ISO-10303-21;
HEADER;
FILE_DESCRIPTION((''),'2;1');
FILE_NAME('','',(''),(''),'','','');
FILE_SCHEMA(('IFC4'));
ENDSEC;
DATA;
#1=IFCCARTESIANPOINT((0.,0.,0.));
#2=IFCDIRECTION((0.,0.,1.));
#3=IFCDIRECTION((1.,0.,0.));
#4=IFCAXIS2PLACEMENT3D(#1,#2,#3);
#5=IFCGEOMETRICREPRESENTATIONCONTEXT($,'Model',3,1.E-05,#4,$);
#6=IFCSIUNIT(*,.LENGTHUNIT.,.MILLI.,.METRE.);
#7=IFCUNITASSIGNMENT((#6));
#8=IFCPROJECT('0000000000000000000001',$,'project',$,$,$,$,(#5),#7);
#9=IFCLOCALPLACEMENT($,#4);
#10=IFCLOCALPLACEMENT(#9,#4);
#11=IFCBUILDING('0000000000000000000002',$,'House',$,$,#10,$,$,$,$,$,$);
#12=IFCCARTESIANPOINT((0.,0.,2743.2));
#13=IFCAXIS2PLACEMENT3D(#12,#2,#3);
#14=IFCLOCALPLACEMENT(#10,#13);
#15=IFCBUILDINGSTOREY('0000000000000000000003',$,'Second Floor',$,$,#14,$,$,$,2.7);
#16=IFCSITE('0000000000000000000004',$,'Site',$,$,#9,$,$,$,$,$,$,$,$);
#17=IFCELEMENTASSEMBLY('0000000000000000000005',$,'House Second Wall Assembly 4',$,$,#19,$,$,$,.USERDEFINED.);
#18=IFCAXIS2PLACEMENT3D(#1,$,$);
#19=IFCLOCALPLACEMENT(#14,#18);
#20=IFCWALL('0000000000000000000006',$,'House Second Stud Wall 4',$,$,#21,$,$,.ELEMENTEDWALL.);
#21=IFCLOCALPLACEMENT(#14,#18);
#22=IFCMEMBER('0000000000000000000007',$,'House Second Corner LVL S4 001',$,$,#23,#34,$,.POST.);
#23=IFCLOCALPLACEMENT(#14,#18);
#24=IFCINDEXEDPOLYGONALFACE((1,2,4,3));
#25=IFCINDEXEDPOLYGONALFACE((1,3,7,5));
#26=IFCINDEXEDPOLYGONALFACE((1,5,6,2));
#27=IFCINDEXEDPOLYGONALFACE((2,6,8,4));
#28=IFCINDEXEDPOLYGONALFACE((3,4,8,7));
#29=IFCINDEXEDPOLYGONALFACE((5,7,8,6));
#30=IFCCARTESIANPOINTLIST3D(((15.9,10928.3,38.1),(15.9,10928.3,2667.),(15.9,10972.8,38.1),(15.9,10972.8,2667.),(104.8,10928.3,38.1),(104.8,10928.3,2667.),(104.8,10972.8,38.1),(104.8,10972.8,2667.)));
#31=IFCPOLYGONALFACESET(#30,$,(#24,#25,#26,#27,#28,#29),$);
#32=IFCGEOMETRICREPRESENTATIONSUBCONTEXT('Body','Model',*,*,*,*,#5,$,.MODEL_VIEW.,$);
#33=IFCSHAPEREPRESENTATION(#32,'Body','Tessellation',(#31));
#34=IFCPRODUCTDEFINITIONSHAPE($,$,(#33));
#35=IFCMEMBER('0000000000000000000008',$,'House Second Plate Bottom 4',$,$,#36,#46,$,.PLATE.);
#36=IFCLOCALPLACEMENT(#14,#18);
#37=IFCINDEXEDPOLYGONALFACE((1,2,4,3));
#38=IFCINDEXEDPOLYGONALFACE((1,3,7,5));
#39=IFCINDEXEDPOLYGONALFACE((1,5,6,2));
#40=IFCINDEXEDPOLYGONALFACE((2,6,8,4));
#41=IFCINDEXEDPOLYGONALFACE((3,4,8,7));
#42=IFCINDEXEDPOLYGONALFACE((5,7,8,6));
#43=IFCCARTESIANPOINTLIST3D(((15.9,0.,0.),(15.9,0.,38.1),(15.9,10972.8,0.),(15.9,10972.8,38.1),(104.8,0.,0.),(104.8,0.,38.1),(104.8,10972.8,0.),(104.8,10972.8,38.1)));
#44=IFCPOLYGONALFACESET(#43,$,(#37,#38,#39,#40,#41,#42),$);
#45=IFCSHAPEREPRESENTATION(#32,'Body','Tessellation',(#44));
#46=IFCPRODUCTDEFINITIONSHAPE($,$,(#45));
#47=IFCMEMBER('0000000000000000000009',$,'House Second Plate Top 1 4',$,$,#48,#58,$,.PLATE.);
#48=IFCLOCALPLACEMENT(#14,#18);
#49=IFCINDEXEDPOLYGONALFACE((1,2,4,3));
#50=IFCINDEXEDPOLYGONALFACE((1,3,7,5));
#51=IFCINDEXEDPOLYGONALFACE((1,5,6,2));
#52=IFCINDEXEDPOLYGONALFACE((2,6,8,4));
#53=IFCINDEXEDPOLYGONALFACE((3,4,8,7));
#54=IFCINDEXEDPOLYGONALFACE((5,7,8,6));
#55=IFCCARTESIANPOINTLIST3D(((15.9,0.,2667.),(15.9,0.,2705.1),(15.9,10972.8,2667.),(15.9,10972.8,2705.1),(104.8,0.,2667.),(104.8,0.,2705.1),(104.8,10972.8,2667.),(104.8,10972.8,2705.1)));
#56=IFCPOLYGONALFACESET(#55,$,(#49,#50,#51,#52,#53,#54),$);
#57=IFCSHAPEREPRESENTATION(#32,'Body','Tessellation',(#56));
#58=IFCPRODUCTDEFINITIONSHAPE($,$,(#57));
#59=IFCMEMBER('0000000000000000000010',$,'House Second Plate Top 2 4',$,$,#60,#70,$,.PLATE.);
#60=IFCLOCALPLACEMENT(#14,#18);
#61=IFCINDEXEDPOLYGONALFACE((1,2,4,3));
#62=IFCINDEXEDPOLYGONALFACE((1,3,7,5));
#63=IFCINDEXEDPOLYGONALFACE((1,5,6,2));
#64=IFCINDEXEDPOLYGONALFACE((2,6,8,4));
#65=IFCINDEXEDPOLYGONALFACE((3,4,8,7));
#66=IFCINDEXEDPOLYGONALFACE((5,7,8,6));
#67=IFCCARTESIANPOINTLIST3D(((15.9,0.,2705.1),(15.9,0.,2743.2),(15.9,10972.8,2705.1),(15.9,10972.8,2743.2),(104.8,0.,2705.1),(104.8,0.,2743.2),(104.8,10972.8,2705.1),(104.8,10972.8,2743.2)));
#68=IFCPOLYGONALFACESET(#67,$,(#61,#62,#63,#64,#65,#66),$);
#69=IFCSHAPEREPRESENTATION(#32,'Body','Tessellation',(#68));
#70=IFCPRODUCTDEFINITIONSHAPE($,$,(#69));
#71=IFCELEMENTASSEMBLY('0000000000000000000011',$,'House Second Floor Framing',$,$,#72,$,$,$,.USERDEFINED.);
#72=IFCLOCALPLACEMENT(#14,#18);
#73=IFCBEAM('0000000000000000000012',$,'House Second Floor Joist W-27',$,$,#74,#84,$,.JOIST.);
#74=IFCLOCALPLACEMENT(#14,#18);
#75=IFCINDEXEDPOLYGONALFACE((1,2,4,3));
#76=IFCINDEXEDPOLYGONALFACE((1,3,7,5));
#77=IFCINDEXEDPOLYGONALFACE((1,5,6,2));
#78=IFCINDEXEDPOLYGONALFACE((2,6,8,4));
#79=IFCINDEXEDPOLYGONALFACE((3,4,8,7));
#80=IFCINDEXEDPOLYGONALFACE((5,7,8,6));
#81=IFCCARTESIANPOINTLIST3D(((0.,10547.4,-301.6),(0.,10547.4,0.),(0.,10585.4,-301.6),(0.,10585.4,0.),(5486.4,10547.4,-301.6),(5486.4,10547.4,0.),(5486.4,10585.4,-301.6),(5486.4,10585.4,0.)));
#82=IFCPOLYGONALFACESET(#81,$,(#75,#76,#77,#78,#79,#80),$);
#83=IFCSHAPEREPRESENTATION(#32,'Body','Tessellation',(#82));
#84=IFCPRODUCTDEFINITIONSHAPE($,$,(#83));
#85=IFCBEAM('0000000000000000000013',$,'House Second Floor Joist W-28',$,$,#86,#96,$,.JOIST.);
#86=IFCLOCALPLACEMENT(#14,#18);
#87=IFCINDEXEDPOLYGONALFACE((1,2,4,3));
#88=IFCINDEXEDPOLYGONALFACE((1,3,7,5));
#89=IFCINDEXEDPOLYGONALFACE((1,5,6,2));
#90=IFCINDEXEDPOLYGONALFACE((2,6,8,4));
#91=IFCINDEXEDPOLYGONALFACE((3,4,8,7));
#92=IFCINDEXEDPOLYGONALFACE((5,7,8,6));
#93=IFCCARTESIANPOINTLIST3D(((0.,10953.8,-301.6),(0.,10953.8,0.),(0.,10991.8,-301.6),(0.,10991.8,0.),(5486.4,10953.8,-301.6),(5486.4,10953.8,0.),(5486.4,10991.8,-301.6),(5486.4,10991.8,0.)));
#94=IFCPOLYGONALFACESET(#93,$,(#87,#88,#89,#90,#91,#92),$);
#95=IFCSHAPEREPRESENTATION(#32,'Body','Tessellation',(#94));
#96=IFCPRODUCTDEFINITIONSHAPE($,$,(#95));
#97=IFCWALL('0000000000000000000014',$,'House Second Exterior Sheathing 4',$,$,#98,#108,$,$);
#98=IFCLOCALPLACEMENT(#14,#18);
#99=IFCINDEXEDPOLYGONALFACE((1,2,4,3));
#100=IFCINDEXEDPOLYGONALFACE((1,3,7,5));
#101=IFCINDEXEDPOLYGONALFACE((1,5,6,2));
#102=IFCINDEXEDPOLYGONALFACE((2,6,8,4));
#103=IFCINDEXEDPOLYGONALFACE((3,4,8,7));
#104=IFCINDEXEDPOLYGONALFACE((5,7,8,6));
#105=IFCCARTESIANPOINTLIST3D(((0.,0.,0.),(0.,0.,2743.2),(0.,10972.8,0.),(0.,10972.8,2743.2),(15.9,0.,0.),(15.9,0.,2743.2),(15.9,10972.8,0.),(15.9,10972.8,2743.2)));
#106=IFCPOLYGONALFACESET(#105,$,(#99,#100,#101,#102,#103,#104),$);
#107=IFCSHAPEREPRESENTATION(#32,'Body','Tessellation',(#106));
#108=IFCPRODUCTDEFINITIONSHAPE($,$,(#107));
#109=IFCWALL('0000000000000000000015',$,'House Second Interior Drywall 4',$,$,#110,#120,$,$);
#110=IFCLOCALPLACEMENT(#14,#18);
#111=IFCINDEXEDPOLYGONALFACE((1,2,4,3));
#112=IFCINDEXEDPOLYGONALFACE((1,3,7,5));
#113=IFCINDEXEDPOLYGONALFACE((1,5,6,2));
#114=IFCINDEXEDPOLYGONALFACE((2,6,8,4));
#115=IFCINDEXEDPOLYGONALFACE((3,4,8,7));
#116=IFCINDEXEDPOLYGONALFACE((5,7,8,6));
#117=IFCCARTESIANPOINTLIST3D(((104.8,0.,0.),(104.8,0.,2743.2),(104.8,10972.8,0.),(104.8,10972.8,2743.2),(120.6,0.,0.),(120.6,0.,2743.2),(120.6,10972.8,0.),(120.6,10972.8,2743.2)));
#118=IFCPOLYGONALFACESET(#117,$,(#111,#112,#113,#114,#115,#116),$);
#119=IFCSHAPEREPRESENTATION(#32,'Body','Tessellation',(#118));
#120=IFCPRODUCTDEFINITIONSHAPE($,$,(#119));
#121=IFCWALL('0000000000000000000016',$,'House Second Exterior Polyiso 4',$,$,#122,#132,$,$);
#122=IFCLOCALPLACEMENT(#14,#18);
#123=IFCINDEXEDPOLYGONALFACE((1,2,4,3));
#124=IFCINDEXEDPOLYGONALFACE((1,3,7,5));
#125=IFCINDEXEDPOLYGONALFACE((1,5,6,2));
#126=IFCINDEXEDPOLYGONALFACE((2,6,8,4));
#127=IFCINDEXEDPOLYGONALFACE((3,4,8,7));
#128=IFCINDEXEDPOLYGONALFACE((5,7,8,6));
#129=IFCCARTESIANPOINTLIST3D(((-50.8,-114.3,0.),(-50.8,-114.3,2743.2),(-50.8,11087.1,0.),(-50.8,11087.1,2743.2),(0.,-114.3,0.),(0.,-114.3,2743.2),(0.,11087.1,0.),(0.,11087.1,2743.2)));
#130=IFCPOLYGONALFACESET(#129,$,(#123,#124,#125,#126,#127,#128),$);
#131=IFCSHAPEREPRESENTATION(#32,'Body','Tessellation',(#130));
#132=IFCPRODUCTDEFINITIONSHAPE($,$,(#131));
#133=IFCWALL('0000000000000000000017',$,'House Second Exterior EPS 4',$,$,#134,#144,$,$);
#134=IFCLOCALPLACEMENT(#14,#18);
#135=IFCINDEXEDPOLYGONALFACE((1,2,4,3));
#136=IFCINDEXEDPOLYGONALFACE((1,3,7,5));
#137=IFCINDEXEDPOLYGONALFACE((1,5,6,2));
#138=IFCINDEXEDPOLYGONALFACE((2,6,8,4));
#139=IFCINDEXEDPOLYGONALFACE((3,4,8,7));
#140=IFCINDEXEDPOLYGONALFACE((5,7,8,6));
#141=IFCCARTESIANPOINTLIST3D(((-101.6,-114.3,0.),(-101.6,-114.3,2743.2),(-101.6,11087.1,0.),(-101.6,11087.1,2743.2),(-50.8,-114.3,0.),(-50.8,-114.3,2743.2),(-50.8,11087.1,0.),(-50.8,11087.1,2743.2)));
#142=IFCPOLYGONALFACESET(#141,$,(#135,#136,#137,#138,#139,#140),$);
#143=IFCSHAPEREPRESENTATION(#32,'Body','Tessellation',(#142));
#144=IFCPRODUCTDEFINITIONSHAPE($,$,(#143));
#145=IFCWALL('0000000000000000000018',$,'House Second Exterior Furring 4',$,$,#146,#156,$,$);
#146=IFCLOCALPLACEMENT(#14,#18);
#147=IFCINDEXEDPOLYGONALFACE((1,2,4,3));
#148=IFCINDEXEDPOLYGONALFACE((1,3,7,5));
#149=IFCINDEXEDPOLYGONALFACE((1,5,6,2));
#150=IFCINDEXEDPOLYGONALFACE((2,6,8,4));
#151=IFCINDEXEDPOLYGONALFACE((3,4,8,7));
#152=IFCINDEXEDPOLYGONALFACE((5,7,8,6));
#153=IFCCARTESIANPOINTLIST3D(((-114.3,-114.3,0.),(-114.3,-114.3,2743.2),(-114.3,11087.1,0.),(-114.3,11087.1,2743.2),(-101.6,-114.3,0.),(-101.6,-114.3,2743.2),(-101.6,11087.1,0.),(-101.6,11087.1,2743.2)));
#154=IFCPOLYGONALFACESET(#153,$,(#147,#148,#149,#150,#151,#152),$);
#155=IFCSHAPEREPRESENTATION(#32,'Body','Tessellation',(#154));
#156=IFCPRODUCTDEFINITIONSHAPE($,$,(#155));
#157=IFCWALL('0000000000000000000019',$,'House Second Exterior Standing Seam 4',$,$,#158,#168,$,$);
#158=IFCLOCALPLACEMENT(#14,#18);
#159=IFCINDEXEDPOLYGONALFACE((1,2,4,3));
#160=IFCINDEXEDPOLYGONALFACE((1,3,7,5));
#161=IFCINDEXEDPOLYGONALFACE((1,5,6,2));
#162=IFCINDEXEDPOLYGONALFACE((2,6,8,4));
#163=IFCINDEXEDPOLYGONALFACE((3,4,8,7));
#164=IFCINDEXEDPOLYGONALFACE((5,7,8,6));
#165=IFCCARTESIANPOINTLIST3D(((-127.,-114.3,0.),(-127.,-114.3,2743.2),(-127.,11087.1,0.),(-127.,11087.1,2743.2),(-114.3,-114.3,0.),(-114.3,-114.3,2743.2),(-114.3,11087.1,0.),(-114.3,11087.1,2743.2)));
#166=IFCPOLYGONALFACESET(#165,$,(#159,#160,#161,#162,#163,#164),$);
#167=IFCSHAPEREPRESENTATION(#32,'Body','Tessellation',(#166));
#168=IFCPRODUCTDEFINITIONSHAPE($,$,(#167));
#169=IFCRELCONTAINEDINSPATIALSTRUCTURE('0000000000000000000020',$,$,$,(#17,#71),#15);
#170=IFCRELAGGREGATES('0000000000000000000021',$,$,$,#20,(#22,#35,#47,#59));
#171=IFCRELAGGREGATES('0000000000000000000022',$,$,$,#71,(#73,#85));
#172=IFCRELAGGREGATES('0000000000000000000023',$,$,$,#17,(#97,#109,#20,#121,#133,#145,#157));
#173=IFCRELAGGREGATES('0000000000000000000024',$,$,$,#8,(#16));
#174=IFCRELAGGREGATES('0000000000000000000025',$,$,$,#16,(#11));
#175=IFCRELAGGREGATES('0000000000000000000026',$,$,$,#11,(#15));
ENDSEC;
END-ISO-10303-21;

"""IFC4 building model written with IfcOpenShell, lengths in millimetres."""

from ifc_helpers import new_model, si_unit, frame, origin_with_axes, origin_2d, place, context, subcontext, project, spatial, indexed_curve, rectangle, outline, extrude, element, aggregate, save


model = new_model("IFC4")

# Units and contexts
model_context = context("Model", 3, precision=1e-05, world=origin_with_axes())
body_context = subcontext(model_context, "Body", "Model", "MODEL_VIEW")
ifc_project = project(units=[si_unit("LENGTHUNIT", "METRE", prefix="MILLI")], contexts=[model_context])

# Site, building, storey
site_placement = place(None, origin_with_axes())
site = spatial("IfcSite", under=ifc_project, at=site_placement, Name="Site")
building_placement = place(site_placement, origin_with_axes())
building = spatial("IfcBuilding", under=site, at=building_placement, Name="House")
storey_placement = place(building_placement, frame((0.0, 0.0, 2743.2), z_axis=(0.0, 0.0, 1.0), x_axis=(1.0, 0.0, 0.0)))
storey = spatial("IfcBuildingStorey", under=building, at=storey_placement, Name="Second Floor", Elevation=2.7)

# Element assembly, wall, members
assembly_1_placement = place(storey_placement, frame((0.0, 0.0, -2743.2), z_axis=(0.0, 0.0, 1.0), x_axis=(1.0, 0.0, 0.0)))
assembly_1 = element("IfcElementAssembly", 1, at=assembly_1_placement, inside=storey, Name="House Second Wall Assembly 4", PredefinedType="USERDEFINED")
wall_1_placement = place(assembly_1_placement, frame((0.0, 10972.8, 2743.2), z_axis=(0.0, 0.0, 1.0), x_axis=(0.0, -1.0, 0.0)))
wall_1 = element("IfcWall", 2, at=wall_1_placement, Name="House Second Stud Wall 4", PredefinedType="ELEMENTEDWALL")
member_1_placement = place(wall_1_placement, frame((22.2, 60.3, 38.1), z_axis=(0.0, 0.0, 1.0), x_axis=(1.0, 0.0, 0.0)))
member_1 = element("IfcMember", 3, at=member_1_placement, Name="House Second Corner LVL S4 001", PredefinedType="POST", context=body_context, shape_type="SweptSolid", body=[
    extrude(rectangle(XDim=44.5, YDim=88.9, at=origin_2d()), origin_with_axes(), (0.0, 0.0, 1.0), 2628.9),
])
member_2_placement = place(wall_1_placement, frame((0.0, 60.3, 19.1), z_axis=(1.0, 0.0, 0.0), x_axis=(0.0, 0.0, 1.0)))
member_2 = element("IfcMember", 4, at=member_2_placement, Name="House Second Plate Bottom 4", PredefinedType="PLATE", context=body_context, shape_type="SweptSolid", body=[
    extrude(rectangle(XDim=38.1, YDim=88.9, at=origin_2d()), origin_with_axes(), (0.0, 0.0, 1.0), 10972.8),
])
member_3_placement = place(wall_1_placement, frame((0.0, 60.3, 2686.1), z_axis=(1.0, 0.0, 0.0), x_axis=(0.0, 0.0, 1.0)))
member_3 = element("IfcMember", 5, at=member_3_placement, Name="House Second Plate Top 1 4", PredefinedType="PLATE", context=body_context, shape_type="SweptSolid", body=[
    extrude(rectangle(XDim=38.1, YDim=88.9, at=origin_2d()), origin_with_axes(), (0.0, 0.0, 1.0), 10972.8),
])
member_4_placement = place(wall_1_placement, frame((0.0, 60.3, 2724.2), z_axis=(1.0, 0.0, 0.0), x_axis=(0.0, 0.0, 1.0)))
member_4 = element("IfcMember", 6, at=member_4_placement, Name="House Second Plate Top 2 4", PredefinedType="PLATE", context=body_context, shape_type="SweptSolid", body=[
    extrude(rectangle(XDim=38.1, YDim=88.9, at=origin_2d()), origin_with_axes(), (0.0, 0.0, 1.0), 10972.8),
])
aggregate(wall_1, [member_1, member_2, member_3, member_4])

# Element assembly, beams
assembly_2_placement = place(storey_placement, frame((0.0, 0.0, -2743.2), z_axis=(0.0, 0.0, 1.0), x_axis=(1.0, 0.0, 0.0)))
assembly_2 = element("IfcElementAssembly", 7, at=assembly_2_placement, inside=storey, Name="House Second Floor Framing", PredefinedType="USERDEFINED")
beam_1_placement = place(assembly_2_placement, frame((0.0, 10566.4, 2592.4), z_axis=(1.0, 0.0, 0.0), x_axis=(0.0, 1.0, 0.0)))
beam_1 = element("IfcBeam", 8, at=beam_1_placement, Name="House Second Floor Joist W-27", PredefinedType="JOIST", context=body_context, shape_type="SweptSolid", body=[
    extrude(rectangle(XDim=38.1, YDim=301.6, at=origin_2d()), origin_with_axes(), (0.0, 0.0, 1.0), 5486.4),
])
beam_2_placement = place(assembly_2_placement, frame((0.0, 10972.8, 2592.4), z_axis=(1.0, 0.0, 0.0), x_axis=(0.0, 1.0, 0.0)))
beam_2 = element("IfcBeam", 9, at=beam_2_placement, Name="House Second Floor Joist W-28", PredefinedType="JOIST", context=body_context, shape_type="SweptSolid", body=[
    extrude(rectangle(XDim=38.1, YDim=301.6, at=origin_2d()), origin_with_axes(), (0.0, 0.0, 1.0), 5486.4),
])
aggregate(assembly_2, [beam_1, beam_2])

# Walls
wall_2_placement = place(assembly_1_placement, frame((0.0, 10972.8, 2743.2), z_axis=(0.0, 0.0, 1.0), x_axis=(0.0, -1.0, 0.0)))
wall_2 = element("IfcWall", 10, at=wall_2_placement, Name="House Second Exterior Sheathing 4", context=body_context, shape_type="SweptSolid", body=[
    extrude(outline(indexed_curve([(0.0, 0.0), (0.0, 15.9), (10972.8, 15.9), (10972.8, 0.0), (0.0, 0.0)], self_intersect=False)), origin_with_axes(), (0.0, 0.0, 1.0), 2743.2),
])
wall_3_placement = place(assembly_1_placement, frame((0.0, 10972.8, 2743.2), z_axis=(0.0, 0.0, 1.0), x_axis=(0.0, -1.0, 0.0)))
wall_3 = element("IfcWall", 11, at=wall_3_placement, Name="House Second Interior Drywall 4", context=body_context, shape_type="SweptSolid", body=[
    extrude(outline(indexed_curve([(0.0, 0.0), (0.0, 15.9), (10972.8, 15.9), (10972.8, 0.0), (0.0, 0.0)], self_intersect=False)), frame((0.0, 104.8, 0.0), z_axis=(0.0, 0.0, 1.0), x_axis=(1.0, 0.0, 0.0)), (0.0, 0.0, 1.0), 2743.2),
])
wall_4_placement = place(assembly_1_placement, frame((0.0, 11087.1, 2743.2), z_axis=(0.0, 0.0, 1.0), x_axis=(0.0, -1.0, 0.0)))
wall_4 = element("IfcWall", 12, at=wall_4_placement, Name="House Second Exterior Polyiso 4", context=body_context, shape_type="SweptSolid", body=[
    extrude(outline(indexed_curve([(0.0, 0.0), (0.0, -50.8), (11201.4, -50.8), (11201.4, 0.0), (0.0, 0.0)], self_intersect=False)), origin_with_axes(), (0.0, 0.0, 1.0), 2743.2),
])
wall_5_placement = place(assembly_1_placement, frame((0.0, 11087.1, 2743.2), z_axis=(0.0, 0.0, 1.0), x_axis=(0.0, -1.0, 0.0)))
wall_5 = element("IfcWall", 13, at=wall_5_placement, Name="House Second Exterior EPS 4", context=body_context, shape_type="SweptSolid", body=[
    extrude(outline(indexed_curve([(0.0, 0.0), (0.0, -50.8), (11201.4, -50.8), (11201.4, 0.0), (0.0, 0.0)], self_intersect=False)), frame((0.0, -50.8, 0.0), z_axis=(0.0, 0.0, 1.0), x_axis=(1.0, 0.0, 0.0)), (0.0, 0.0, 1.0), 2743.2),
])
wall_6_placement = place(assembly_1_placement, frame((0.0, 11087.1, 2743.2), z_axis=(0.0, 0.0, 1.0), x_axis=(0.0, -1.0, 0.0)))
wall_6 = element("IfcWall", 14, at=wall_6_placement, Name="House Second Exterior Furring 4", context=body_context, shape_type="SweptSolid", body=[
    extrude(outline(indexed_curve([(0.0, 0.0), (0.0, -12.7), (11201.4, -12.7), (11201.4, 0.0), (0.0, 0.0)], self_intersect=False)), frame((0.0, -101.6, 0.0), z_axis=(0.0, 0.0, 1.0), x_axis=(1.0, 0.0, 0.0)), (0.0, 0.0, 1.0), 2743.2),
])
wall_7_placement = place(assembly_1_placement, frame((0.0, 11087.1, 2743.2), z_axis=(0.0, 0.0, 1.0), x_axis=(0.0, -1.0, 0.0)))
wall_7 = element("IfcWall", 15, at=wall_7_placement, Name="House Second Exterior Standing Seam 4", context=body_context, shape_type="SweptSolid", body=[
    extrude(outline(indexed_curve([(0.0, 0.0), (0.0, -12.7), (11201.4, -12.7), (11201.4, 0.0), (0.0, 0.0)], self_intersect=False)), frame((0.0, -114.3, 0.0), z_axis=(0.0, 0.0, 1.0), x_axis=(1.0, 0.0, 0.0)), (0.0, 0.0, 1.0), 2743.2),
])
aggregate(assembly_1, [wall_2, wall_3, wall_1, wall_4, wall_5, wall_6, wall_7])

save(model, "model.ifc")
